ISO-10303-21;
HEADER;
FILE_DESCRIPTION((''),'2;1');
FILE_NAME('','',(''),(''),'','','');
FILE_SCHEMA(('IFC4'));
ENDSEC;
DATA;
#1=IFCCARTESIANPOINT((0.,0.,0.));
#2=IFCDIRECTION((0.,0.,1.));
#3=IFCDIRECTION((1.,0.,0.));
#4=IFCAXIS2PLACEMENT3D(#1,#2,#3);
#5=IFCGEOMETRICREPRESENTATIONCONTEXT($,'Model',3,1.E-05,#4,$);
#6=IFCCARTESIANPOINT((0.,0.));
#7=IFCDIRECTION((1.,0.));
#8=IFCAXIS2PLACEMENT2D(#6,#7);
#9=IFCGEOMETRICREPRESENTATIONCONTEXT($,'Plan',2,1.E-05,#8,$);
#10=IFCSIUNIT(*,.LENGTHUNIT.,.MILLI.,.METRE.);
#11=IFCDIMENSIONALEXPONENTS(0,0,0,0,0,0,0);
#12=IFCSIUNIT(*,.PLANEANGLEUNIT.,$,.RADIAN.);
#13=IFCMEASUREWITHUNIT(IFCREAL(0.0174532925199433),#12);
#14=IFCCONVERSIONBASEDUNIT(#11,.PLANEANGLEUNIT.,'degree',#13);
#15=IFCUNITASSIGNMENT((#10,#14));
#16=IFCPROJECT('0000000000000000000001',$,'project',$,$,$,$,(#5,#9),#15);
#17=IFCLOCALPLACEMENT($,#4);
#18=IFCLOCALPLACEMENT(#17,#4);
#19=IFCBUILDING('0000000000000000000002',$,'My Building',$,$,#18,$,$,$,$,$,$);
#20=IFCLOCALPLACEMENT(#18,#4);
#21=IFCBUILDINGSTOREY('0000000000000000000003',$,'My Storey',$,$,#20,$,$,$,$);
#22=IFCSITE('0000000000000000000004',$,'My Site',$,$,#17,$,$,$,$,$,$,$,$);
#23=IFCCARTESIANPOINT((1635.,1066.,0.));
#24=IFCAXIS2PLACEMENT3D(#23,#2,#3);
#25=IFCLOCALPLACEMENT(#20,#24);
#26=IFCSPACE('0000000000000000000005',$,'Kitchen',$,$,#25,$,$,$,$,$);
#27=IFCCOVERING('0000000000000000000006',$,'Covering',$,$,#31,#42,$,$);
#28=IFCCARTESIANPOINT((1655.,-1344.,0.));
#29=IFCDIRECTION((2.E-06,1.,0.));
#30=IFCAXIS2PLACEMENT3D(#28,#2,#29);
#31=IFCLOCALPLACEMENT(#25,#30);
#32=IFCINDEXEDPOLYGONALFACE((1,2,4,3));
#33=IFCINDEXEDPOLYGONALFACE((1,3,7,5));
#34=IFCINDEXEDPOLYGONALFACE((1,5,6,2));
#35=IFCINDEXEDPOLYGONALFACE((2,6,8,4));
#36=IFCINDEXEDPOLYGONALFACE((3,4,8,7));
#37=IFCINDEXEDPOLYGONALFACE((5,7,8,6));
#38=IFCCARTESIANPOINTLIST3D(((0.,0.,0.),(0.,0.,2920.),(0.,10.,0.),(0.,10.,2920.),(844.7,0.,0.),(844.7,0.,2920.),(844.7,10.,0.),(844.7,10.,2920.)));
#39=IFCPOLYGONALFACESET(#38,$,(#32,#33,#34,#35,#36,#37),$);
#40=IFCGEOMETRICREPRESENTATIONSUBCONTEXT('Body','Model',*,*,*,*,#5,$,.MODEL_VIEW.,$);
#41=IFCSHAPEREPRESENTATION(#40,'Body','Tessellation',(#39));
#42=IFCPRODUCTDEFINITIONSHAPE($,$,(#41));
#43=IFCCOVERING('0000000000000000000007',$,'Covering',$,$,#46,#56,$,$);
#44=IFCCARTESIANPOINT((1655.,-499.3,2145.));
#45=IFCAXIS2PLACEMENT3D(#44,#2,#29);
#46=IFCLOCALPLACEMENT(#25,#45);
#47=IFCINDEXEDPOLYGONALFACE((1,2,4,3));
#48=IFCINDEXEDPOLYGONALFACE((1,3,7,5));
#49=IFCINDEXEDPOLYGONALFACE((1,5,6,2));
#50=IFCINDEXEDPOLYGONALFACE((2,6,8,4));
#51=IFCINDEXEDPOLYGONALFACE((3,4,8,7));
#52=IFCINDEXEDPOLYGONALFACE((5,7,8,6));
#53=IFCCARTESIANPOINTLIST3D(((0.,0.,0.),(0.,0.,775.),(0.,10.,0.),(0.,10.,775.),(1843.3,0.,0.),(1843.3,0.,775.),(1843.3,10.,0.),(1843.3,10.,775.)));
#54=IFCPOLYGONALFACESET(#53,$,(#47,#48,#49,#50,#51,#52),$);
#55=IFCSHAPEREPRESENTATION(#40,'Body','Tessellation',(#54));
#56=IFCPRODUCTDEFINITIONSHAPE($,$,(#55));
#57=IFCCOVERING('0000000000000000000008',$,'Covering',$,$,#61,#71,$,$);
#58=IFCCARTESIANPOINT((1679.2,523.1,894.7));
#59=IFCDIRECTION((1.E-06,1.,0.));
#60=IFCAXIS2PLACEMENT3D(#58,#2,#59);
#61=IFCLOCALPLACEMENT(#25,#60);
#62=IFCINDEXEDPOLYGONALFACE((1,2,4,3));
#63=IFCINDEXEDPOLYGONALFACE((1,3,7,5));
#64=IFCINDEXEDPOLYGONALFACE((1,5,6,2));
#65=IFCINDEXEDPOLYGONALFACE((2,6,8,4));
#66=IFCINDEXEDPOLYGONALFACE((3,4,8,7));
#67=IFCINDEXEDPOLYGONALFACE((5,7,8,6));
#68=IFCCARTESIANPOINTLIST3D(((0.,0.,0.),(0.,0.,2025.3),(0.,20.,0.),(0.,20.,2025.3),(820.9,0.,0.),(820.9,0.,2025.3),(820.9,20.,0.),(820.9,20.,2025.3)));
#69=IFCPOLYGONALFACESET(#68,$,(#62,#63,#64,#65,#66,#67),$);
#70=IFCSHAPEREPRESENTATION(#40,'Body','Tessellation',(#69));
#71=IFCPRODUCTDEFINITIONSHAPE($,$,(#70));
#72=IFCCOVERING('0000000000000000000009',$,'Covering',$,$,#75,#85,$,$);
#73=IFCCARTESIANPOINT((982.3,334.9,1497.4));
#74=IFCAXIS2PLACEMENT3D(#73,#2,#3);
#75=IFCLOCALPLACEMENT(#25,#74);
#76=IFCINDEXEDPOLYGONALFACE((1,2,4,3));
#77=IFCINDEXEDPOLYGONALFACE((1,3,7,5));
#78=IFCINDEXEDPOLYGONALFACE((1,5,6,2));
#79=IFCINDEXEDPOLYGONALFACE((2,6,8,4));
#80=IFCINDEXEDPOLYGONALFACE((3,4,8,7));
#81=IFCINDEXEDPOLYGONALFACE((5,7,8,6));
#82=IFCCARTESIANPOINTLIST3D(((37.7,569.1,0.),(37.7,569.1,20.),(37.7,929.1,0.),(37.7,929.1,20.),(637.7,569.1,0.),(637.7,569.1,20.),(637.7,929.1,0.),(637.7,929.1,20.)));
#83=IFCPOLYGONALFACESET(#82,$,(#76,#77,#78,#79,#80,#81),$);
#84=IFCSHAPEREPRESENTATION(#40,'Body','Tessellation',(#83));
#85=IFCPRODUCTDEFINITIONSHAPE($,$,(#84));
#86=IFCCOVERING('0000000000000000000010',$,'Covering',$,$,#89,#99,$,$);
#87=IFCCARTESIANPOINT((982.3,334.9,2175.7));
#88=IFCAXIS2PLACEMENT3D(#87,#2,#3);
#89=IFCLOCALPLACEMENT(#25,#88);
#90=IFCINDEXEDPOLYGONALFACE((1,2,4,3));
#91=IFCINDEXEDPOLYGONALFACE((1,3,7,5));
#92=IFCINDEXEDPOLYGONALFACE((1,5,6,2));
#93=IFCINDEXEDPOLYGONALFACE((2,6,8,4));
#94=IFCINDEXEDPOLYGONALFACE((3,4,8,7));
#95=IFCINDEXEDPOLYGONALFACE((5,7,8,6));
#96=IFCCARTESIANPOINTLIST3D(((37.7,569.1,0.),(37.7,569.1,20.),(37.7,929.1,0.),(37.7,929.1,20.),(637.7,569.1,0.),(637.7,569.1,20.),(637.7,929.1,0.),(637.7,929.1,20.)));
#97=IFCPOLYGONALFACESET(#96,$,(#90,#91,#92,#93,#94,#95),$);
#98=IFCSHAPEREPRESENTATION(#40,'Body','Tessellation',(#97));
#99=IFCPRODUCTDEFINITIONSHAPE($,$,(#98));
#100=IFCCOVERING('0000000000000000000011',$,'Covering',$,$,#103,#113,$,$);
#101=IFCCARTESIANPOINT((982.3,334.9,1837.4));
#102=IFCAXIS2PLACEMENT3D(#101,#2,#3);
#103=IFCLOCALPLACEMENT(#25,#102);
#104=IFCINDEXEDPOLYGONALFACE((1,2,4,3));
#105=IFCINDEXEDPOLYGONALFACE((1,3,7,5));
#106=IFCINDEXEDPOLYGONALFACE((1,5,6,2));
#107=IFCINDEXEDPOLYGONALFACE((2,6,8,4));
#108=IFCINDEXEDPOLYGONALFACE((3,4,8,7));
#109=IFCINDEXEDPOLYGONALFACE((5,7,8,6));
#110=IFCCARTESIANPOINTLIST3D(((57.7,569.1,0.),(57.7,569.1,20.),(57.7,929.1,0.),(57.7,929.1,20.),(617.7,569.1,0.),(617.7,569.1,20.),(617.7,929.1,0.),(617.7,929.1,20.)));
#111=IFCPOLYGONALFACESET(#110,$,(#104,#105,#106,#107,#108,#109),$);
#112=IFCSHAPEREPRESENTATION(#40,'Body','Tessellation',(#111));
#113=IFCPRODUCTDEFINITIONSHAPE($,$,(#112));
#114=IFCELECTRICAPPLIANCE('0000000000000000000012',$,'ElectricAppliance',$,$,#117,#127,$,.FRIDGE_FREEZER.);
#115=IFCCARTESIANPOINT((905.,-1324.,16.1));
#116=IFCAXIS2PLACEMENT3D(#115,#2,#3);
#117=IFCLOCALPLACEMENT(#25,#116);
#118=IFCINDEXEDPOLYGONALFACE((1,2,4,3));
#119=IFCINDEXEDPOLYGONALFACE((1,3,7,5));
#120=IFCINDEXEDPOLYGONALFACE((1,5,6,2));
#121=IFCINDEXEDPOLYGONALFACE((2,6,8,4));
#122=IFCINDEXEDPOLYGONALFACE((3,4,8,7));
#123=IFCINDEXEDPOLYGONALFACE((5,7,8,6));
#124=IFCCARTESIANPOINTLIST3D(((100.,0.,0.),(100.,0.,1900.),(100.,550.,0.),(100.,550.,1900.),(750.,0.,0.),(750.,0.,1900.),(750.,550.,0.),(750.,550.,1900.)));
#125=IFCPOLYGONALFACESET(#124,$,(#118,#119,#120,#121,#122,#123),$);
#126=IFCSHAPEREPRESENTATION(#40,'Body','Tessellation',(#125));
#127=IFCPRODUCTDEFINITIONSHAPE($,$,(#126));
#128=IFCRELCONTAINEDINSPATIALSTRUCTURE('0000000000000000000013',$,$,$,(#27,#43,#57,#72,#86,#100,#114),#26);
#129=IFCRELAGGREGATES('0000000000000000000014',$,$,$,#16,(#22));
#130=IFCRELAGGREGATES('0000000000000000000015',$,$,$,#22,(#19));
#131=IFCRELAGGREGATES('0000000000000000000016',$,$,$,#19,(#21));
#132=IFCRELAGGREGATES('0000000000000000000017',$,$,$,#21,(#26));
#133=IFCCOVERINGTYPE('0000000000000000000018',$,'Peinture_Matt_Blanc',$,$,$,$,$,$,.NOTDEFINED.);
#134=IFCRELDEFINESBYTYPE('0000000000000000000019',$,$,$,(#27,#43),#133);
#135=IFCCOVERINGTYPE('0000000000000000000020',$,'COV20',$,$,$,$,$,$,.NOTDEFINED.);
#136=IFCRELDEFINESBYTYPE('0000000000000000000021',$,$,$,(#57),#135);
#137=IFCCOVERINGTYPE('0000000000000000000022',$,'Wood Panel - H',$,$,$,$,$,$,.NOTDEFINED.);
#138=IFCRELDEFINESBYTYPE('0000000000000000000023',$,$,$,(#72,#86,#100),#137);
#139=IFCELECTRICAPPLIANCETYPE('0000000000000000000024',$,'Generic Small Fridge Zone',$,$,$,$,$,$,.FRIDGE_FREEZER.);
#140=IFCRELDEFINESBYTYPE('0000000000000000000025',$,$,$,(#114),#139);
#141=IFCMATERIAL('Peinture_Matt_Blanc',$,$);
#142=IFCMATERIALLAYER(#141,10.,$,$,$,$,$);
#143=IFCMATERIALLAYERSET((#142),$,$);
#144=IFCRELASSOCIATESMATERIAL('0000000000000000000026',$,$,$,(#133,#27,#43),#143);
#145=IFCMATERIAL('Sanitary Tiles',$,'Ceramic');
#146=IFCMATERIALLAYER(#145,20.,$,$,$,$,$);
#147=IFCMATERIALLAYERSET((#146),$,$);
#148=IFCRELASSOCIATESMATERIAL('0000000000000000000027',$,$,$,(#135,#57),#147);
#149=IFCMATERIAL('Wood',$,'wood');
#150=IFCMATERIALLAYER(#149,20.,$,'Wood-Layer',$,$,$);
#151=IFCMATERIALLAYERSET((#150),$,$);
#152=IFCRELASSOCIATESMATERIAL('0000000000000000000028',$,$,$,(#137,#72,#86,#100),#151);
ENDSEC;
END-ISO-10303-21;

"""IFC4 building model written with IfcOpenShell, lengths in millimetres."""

from ifc_helpers import new_model, entity, si_unit, converted_unit, frame, origin_with_axes, origin_2d_with_axis, place, context, subcontext, project, spatial, line, indexed_curve, outline, extrude, clip, halfspace, shape, source, transform, mapped, material, layer, layer_set, layer_usage, type_object, type_shapes, element, save


model = new_model("IFC4")

# Units and contexts
model_context = context("Model", 3, precision=1e-05, world=origin_with_axes())
plan_context = context("Plan", 2, precision=1e-05, world=origin_2d_with_axis())
body_context_1 = subcontext(model_context, "Body", "Model", "MODEL_VIEW")
body_context_2 = subcontext(plan_context, "Body", "Plan", "PLAN_VIEW")
ifc_project = project(units=[si_unit("LENGTHUNIT", "METRE", prefix="MILLI"), converted_unit("PLANEANGLEUNIT", "degree", entity("IfcReal", 0.0174532925199433), si_unit("PLANEANGLEUNIT", "RADIAN"), dimensions=[0, 0, 0, 0, 0, 0, 0])], contexts=[model_context, plan_context])

# Site, building, storey
site_placement = place(None, origin_with_axes())
site = spatial("IfcSite", under=ifc_project, at=site_placement, Name="My Site")
building_placement = place(site_placement, origin_with_axes())
building = spatial("IfcBuilding", under=site, at=building_placement, Name="My Building")
storey_placement = place(building_placement, origin_with_axes())
storey = spatial("IfcBuildingStorey", under=building, at=storey_placement, Name="My Storey")

# Shared definitions
space_1_placement = place(storey_placement, frame((1635.0, 1066.0, 0.0), z_axis=(0.0, 0.0, 1.0), x_axis=(1.0, 0.0, 0.0)))
space_1 = spatial("IfcSpace", under=storey, at=space_1_placement, Name="Kitchen")

# Coverings
ifc_material_1 = material(Name="Peinture_Matt_Blanc")
ifc_layer_1 = layer(ifc_material_1, 10.0)
ifc_layer_set_1 = layer_set([ifc_layer_1])
ifc_layer_usage_1 = layer_usage(ifc_layer_set_1, "AXIS2", "POSITIVE", 0.0)
covering_type_1 = type_object("IfcCoveringType", Name="Peinture_Matt_Blanc", PredefinedType="NOTDEFINED", material=ifc_layer_set_1)
covering_1_placement = place(space_1_placement, frame((1655.0, -1344.0, 0.0), z_axis=(0.0, 0.0, 1.0), x_axis=(0.000002, 1.0, 0.0)))
element("IfcCovering", 1, at=covering_1_placement, inside=space_1, type_object=covering_type_1, material=ifc_layer_usage_1, Name="Covering", context=body_context_1, shape_type="Clipping", body=[
    clip(clip(extrude(outline(indexed_curve([(0.0, 0.0), (0.0, 10.0), (844.7, 10.0), (844.7, 0.0), (0.0, 0.0)], self_intersect=False)), origin_with_axes(), (0.0, 0.0, 1.0), 2920.0), halfspace(frame((0.0, 0.0, 2920.0), z_axis=(0.0, 0.0, 1.0), x_axis=(-1.0, 0.0, 0.0)), False)), halfspace(frame((0.0, 0.0, 2920.0), z_axis=(0.0, 0.0, 1.0), x_axis=(-1.0, 0.0, 0.0)), False)),
])
ifc_layer_usage_2 = layer_usage(ifc_layer_set_1, "AXIS2", "POSITIVE", 0.0)
covering_2_placement = place(space_1_placement, frame((1655.0, -499.3, 2145.0), z_axis=(0.0, 0.0, 1.0), x_axis=(0.000002, 1.0, 0.0)))
element("IfcCovering", 2, at=covering_2_placement, inside=space_1, type_object=covering_type_1, material=ifc_layer_usage_2, Name="Covering", context=body_context_1, shape_type="Clipping", body=[
    clip(clip(extrude(outline(indexed_curve([(0.0, 0.0), (0.0, 10.0), (1843.3, 10.0), (1843.3, 0.0), (0.0, 0.0)], self_intersect=False)), origin_with_axes(), (0.0, 0.0, 1.0), 775.0), halfspace(frame((0.0, 0.0, 775.0), z_axis=(0.0, 0.0, 1.0), x_axis=(-1.0, 0.0, 0.0)), False)), halfspace(frame((0.0, 0.0, 775.0), z_axis=(0.0, 0.0, 1.0), x_axis=(-1.0, 0.0, 0.0)), False)),
])

# Coverings
ifc_material_2 = material(Name="Sanitary Tiles", Category="Ceramic")
ifc_layer_2 = layer(ifc_material_2, 20.0)
ifc_layer_set_2 = layer_set([ifc_layer_2])
ifc_layer_usage_3 = layer_usage(ifc_layer_set_2, "AXIS2", "POSITIVE", 0.0)
covering_type_2 = type_object("IfcCoveringType", Name="COV20", PredefinedType="NOTDEFINED", material=ifc_layer_set_2)
covering_3_placement = place(space_1_placement, frame((1679.2, 523.1, 894.7), z_axis=(0.0, 0.0, 1.0), x_axis=(0.000001, 1.0, 0.0)))
element("IfcCovering", 3, at=covering_3_placement, inside=space_1, type_object=covering_type_2, material=ifc_layer_usage_3, Name="Covering", context=body_context_1, shape_type="Clipping", body=[
    clip(clip(extrude(outline(indexed_curve([(0.0, 0.0), (0.0, 20.0), (820.9, 20.0), (820.9, 0.0), (0.0, 0.0)], self_intersect=False)), origin_with_axes(), (0.0, 0.0, 1.0), 2025.3), halfspace(frame((0.0, 0.0, 2025.3), z_axis=(0.0, 0.0, 1.0), x_axis=(-1.0, 0.0, 0.0)), False)), halfspace(frame((0.0, 0.0, 2025.3), z_axis=(0.0, 0.0, 1.0), x_axis=(-1.0, 0.0, 0.0)), False)),
])
ifc_material_3 = material(Name="Wood", Category="wood")
ifc_layer_3 = layer(ifc_material_3, 20.0, Name="Wood-Layer")
ifc_layer_set_3 = layer_set([ifc_layer_3])
ifc_layer_usage_4 = layer_usage(ifc_layer_set_3, "AXIS3", "POSITIVE", 0.0)
covering_type_3 = type_object("IfcCoveringType", Name="Wood Panel - H", PredefinedType="NOTDEFINED", material=ifc_layer_set_3)
covering_4_placement = place(space_1_placement, frame((982.3, 334.9, 1497.4), z_axis=(0.0, 0.0, 1.0), x_axis=(1.0, 0.0, 0.0)))
element("IfcCovering", 4, at=covering_4_placement, inside=space_1, type_object=covering_type_3, material=ifc_layer_usage_4, Name="Covering", context=body_context_1, shape_type="SweptSolid", body=[
    extrude(outline(indexed_curve([(637.7, 569.1), (637.7, 929.1), (37.7, 929.1), (37.7, 569.1), (637.7, 569.1)])), None, (0.0, 0.0, 1.0), 20.0),
])
ifc_layer_usage_5 = layer_usage(ifc_layer_set_3, "AXIS3", "POSITIVE", 0.0)
covering_5_placement = place(space_1_placement, frame((982.3, 334.9, 2175.7), z_axis=(0.0, 0.0, 1.0), x_axis=(1.0, 0.0, 0.0)))
element("IfcCovering", 5, at=covering_5_placement, inside=space_1, type_object=covering_type_3, material=ifc_layer_usage_5, Name="Covering", context=body_context_1, shape_type="SweptSolid", body=[
    extrude(outline(indexed_curve([(37.7, 569.1), (37.7, 929.1), (637.7, 929.1), (637.7, 569.1), (37.7, 569.1)])), None, (0.0, 0.0, 1.0), 20.0),
])
ifc_layer_usage_6 = layer_usage(ifc_layer_set_3, "AXIS3", "POSITIVE", 0.0)
covering_6_placement = place(space_1_placement, frame((982.3, 334.9, 1837.4), z_axis=(0.0, 0.0, 1.0), x_axis=(1.0, 0.0, 0.0)))
element("IfcCovering", 6, at=covering_6_placement, inside=space_1, type_object=covering_type_3, material=ifc_layer_usage_6, Name="Covering", context=body_context_1, shape_type="SweptSolid", body=[
    extrude(outline(indexed_curve([(57.7, 569.1), (57.7, 929.1), (617.7, 929.1), (617.7, 569.1), (57.7, 569.1)])), None, (0.0, 0.0, 1.0), 20.0),
])

# Electric appliance
electric_appliance_type = type_object("IfcElectricApplianceType", Name="Generic Small Fridge Zone", PredefinedType="FRIDGE_FREEZER")
shared_shape_1 = source(origin_with_axes(), body_context_1, "Body", "SweptSolid", [
    extrude(outline(indexed_curve([(750.0, 550.0), (750.0, 0.0), (100.0, 0.0), (100.0, 550.0)], segments=[line(3, 2), line(2, 1), line(1, 4), line(4, 3)], self_intersect=False)), origin_with_axes(), (0.0, 0.0, 1.0), 1900.0),
])
shared_shape_2 = source(origin_with_axes(), body_context_2, "Body", "Curve2D", [
    entity("IfcIndexedPolyCurve", entity("IfcCartesianPointList2D", [[0.0, 0.0], [750.0, 0.0], [750.0, 650.0], [0.0, 650.0]]), [entity("IfcLineIndex", [1, 2, 3, 4, 1])]),
])
type_shapes(electric_appliance_type, [shared_shape_1, shared_shape_2])
electric_appliance_placement = place(space_1_placement, frame((905.0, -1324.0, 16.1), z_axis=(0.0, 0.0, 1.0), x_axis=(1.0, 0.0, 0.0)))
element("IfcElectricAppliance", 7, at=electric_appliance_placement, inside=space_1, type_object=electric_appliance_type, Name="ElectricAppliance", PredefinedType="FRIDGE_FREEZER", shapes=[
    shape(body_context_1, "Body", "MappedRepresentation", [mapped(shared_shape_1, transform((0.0, 0.0, 0.0), x_axis=(1.0, 0.0, 0.0), y_axis=(0.0, 1.0, 0.0), z_axis=(0.0, 0.0, 1.0), scale=1.0))]),
    shape(body_context_2, "Body", "MappedRepresentation", [mapped(shared_shape_2, transform((0.0, 0.0, 0.0), x_axis=(1.0, 0.0, 0.0), y_axis=(0.0, 1.0, 0.0), z_axis=(0.0, 0.0, 1.0), scale=1.0))]),
])

save(model, "model.ifc")
